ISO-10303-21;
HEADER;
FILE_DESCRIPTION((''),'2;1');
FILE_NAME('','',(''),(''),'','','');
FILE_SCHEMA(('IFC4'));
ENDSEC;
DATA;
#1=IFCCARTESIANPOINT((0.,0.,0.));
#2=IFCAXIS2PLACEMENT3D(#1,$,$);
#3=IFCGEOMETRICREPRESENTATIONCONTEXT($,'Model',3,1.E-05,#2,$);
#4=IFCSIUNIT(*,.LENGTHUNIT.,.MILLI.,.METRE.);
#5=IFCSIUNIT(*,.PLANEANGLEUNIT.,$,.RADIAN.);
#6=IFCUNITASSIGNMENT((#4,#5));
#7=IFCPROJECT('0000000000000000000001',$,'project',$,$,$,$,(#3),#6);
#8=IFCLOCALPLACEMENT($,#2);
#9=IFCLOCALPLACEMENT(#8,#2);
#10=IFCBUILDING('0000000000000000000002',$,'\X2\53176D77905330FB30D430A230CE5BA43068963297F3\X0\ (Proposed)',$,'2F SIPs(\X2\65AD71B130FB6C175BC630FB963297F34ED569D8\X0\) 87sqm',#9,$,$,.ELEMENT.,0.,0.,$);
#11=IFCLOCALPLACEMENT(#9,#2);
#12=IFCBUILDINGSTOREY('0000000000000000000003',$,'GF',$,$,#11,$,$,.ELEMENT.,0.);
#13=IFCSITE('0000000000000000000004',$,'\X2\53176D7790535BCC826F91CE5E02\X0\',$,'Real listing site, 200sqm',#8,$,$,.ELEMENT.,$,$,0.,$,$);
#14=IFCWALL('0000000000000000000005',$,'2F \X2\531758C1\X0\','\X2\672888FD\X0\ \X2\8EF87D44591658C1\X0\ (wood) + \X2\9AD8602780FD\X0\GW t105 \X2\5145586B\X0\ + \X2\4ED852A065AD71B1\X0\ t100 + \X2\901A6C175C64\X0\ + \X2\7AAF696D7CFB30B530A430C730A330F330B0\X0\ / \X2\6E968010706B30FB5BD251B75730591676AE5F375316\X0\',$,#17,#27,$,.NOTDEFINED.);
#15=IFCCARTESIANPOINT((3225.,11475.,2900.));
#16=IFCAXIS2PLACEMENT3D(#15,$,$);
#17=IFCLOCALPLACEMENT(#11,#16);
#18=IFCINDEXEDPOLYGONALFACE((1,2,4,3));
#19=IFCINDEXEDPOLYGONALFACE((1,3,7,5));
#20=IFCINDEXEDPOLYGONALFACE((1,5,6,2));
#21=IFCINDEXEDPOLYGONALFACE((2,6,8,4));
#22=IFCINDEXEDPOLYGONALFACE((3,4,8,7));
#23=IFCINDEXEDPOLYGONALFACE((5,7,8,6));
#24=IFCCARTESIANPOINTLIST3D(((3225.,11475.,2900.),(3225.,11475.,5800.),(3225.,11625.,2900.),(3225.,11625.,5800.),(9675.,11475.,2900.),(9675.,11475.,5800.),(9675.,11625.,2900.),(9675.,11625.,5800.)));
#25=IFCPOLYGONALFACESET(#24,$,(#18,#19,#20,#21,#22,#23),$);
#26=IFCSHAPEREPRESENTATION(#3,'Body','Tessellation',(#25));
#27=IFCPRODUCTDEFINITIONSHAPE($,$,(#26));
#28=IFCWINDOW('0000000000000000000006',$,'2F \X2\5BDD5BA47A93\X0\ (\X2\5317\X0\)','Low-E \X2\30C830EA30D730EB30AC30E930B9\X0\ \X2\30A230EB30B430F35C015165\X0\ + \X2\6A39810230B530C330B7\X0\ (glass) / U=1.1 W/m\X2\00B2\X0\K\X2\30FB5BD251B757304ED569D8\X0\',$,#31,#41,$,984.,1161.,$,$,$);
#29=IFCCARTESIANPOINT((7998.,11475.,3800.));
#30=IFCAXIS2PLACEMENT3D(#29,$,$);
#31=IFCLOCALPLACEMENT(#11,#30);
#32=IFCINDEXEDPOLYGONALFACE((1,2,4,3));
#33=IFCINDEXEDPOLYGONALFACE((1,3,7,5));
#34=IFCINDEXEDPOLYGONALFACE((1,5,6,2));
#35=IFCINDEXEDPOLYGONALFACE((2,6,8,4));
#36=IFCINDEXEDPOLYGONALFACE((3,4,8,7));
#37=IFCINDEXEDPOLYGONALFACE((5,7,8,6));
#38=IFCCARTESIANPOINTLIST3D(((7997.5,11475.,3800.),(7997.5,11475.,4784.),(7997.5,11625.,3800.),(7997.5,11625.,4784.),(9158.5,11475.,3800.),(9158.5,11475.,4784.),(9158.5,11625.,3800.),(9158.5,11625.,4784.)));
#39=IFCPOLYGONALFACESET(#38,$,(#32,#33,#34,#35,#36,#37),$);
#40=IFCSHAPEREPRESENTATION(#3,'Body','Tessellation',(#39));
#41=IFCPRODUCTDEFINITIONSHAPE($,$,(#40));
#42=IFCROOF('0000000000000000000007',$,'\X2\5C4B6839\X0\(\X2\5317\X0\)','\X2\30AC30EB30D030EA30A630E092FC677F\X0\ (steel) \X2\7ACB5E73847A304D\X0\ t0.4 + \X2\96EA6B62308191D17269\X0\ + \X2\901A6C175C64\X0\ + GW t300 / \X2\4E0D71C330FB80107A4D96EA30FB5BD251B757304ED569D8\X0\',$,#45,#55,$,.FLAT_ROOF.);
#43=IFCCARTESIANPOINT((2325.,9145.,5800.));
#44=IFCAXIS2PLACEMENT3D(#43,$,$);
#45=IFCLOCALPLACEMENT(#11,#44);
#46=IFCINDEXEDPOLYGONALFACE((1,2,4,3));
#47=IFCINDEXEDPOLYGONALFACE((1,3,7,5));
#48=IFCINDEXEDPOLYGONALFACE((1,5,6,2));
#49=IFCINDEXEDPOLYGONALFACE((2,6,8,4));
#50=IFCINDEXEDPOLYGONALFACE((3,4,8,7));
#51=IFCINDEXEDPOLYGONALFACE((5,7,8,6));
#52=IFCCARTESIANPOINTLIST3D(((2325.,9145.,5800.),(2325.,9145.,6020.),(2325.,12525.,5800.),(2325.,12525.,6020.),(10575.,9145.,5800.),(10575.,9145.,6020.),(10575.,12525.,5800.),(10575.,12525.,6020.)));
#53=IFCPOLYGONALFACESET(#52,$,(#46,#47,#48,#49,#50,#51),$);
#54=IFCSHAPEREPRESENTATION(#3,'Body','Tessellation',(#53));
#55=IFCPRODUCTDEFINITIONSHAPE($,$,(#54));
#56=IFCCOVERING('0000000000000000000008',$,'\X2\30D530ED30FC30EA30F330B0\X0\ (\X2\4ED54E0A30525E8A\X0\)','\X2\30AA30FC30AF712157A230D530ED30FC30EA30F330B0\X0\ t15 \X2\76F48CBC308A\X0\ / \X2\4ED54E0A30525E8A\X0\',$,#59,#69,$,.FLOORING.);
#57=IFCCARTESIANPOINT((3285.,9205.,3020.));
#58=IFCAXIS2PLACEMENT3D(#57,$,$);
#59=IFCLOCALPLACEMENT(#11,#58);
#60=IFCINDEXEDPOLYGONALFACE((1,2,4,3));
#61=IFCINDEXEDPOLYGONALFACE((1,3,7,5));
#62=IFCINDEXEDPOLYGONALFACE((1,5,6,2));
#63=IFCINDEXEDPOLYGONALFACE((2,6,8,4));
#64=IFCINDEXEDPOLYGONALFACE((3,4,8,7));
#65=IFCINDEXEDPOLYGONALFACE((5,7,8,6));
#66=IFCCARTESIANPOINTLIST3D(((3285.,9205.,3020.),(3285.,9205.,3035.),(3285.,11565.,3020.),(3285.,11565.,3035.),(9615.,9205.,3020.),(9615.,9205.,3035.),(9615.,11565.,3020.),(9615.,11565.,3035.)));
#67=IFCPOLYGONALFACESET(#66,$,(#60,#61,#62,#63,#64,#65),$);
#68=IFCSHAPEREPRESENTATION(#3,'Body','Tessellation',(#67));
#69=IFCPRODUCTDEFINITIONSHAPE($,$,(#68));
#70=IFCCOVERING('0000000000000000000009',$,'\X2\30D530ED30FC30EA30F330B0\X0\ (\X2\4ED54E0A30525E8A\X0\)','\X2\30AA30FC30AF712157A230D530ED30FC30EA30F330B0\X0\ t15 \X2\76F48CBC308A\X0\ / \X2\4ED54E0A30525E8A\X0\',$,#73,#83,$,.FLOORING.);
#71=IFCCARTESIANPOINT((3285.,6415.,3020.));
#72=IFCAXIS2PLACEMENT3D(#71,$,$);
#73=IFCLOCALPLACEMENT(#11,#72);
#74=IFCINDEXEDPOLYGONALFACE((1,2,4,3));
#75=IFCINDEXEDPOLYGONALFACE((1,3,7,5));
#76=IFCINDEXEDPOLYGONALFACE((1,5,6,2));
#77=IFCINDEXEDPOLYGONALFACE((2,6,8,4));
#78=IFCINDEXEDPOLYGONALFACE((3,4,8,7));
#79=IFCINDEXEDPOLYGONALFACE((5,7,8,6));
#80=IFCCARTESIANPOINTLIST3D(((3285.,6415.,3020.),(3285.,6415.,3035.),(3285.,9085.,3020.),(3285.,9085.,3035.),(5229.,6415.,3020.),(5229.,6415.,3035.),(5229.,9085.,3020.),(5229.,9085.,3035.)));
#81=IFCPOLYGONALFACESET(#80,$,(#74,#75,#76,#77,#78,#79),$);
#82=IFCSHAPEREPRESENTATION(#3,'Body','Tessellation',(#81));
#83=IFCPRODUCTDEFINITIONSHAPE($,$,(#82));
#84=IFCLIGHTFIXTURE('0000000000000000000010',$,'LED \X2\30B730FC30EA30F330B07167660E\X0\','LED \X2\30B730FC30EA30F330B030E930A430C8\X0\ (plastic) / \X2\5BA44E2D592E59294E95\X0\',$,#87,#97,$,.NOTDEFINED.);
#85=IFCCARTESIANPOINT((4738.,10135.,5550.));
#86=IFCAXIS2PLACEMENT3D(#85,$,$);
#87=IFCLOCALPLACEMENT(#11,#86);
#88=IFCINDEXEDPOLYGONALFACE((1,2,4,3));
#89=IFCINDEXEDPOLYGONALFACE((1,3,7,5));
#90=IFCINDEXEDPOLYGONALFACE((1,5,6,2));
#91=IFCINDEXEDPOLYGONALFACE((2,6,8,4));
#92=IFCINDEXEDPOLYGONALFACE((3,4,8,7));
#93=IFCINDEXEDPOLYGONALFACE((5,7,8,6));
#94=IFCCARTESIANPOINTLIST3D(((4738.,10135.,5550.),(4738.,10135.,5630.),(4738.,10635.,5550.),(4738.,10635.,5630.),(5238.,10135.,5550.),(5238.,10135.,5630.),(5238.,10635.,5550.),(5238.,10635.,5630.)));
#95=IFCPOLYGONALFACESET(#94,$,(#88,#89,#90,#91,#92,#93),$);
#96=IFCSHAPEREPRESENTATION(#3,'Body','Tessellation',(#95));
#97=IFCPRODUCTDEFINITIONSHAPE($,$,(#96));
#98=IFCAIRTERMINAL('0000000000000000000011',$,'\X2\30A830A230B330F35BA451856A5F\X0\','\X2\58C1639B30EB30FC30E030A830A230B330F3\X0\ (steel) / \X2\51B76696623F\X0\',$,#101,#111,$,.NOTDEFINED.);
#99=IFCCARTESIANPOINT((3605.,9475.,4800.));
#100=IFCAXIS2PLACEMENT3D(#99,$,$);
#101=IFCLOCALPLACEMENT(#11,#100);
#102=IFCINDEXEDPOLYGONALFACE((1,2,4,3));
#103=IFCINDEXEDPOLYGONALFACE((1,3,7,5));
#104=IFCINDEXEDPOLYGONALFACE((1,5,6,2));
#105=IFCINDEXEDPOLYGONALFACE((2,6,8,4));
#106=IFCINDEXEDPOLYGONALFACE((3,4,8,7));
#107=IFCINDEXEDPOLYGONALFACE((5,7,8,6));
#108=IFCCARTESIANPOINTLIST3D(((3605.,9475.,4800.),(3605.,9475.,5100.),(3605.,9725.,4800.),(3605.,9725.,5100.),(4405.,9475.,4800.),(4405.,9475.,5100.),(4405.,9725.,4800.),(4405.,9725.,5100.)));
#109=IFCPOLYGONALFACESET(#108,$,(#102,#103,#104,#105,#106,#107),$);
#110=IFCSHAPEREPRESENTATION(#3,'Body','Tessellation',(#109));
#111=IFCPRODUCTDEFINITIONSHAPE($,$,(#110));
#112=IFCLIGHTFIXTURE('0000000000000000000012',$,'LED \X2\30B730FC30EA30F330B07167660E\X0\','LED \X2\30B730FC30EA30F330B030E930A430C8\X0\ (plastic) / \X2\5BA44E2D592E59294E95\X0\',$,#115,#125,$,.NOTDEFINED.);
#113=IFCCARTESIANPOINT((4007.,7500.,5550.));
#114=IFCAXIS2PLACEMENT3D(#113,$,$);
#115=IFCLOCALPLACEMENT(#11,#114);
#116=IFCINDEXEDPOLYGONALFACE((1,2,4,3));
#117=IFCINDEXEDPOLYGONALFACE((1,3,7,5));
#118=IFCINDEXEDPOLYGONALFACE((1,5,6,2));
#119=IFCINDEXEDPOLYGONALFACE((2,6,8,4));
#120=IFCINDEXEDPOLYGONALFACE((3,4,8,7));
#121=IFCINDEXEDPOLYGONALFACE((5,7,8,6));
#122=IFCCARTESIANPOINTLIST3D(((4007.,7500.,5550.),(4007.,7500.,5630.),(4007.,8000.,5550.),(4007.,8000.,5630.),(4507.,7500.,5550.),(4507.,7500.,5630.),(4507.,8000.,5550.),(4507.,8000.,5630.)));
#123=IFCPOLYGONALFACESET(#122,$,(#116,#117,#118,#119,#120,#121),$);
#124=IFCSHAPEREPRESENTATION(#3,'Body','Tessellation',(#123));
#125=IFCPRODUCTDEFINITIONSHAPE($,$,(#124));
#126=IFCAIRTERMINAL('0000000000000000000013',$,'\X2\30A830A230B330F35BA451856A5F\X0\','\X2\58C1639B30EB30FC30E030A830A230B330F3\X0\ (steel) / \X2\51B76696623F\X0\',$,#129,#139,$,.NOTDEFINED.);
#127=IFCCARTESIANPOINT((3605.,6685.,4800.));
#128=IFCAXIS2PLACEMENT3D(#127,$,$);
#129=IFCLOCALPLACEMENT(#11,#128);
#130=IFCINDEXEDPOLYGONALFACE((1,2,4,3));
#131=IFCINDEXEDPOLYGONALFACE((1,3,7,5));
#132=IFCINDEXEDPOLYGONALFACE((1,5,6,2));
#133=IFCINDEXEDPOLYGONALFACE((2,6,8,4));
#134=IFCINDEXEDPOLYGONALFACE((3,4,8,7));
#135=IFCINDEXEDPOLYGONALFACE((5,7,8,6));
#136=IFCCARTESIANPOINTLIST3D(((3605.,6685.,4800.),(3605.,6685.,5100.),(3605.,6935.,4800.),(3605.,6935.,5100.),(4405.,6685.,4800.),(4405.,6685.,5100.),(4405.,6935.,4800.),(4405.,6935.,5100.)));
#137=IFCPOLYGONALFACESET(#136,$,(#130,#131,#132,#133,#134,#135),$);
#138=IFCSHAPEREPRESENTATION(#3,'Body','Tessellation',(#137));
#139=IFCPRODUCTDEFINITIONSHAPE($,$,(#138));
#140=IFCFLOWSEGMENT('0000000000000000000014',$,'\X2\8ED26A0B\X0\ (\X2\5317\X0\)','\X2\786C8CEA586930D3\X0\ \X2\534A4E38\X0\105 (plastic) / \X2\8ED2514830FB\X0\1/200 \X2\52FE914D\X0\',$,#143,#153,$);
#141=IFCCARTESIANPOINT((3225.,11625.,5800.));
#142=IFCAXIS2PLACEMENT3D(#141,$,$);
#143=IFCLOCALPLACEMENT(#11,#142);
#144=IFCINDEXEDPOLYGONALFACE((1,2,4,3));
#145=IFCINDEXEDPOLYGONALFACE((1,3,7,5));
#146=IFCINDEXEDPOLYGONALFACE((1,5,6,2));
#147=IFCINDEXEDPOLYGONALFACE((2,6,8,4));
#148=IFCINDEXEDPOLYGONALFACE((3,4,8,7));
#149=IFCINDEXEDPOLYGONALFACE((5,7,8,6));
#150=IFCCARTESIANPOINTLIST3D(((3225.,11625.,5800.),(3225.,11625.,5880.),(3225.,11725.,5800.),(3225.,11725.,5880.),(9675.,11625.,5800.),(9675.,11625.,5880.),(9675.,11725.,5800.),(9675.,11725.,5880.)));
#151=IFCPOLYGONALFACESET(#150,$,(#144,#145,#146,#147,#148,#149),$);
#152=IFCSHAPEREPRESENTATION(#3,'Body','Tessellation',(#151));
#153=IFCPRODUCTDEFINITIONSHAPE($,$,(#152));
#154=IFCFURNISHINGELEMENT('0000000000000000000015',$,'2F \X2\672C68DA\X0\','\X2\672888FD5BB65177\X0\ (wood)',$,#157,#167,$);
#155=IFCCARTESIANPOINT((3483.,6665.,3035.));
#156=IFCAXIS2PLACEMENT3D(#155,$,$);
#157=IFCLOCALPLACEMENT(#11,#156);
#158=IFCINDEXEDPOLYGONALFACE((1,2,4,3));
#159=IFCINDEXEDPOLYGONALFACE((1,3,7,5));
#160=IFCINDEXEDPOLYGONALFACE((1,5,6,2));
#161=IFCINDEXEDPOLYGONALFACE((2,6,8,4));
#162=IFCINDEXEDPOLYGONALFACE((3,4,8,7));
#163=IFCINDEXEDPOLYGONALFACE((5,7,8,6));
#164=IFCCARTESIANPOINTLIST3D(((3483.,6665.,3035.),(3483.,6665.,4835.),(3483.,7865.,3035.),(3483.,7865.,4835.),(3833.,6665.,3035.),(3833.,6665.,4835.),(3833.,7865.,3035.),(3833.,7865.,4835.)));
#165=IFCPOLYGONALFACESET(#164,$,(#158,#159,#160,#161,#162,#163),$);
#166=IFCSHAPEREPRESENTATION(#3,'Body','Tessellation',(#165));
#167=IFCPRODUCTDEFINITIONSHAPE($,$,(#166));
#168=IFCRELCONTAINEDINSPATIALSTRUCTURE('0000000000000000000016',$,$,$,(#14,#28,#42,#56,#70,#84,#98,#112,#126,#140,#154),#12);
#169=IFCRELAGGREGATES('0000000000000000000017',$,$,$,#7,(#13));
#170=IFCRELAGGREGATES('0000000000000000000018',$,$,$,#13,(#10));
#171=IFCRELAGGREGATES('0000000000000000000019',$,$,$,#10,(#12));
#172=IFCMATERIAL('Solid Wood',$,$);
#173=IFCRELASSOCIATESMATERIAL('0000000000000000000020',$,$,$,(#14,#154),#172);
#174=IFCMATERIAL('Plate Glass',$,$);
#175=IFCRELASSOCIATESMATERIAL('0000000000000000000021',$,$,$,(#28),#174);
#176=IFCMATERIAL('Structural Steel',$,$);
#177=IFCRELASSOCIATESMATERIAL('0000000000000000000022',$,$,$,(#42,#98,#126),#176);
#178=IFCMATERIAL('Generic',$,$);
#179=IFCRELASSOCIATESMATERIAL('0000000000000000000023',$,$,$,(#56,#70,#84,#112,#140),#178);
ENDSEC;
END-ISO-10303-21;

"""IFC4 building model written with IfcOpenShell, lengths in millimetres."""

from ifc_helpers import new_model, si_unit, frame, frame_2d, origin, place, context, project, spatial, rectangle, extrude, material, element, fill, save


model = new_model("IFC4")

# Units and contexts
model_context = context("Model", 3, precision=1e-05, world=origin())
ifc_project = project(units=[si_unit("LENGTHUNIT", "METRE", prefix="MILLI"), si_unit("PLANEANGLEUNIT", "RADIAN")], contexts=[model_context])

# Site, building, storey
site_placement = place(None, origin())
site = spatial("IfcSite", under=ifc_project, at=site_placement, Name="北海道富良野市", ObjectType="Real listing site, 200sqm", CompositionType="ELEMENT", RefElevation=0.0)
building_placement = place(site_placement, origin())
building = spatial("IfcBuilding", under=site, at=building_placement, Name="北海道・ピアノ室と防音 (Proposed)", ObjectType="2F SIPs(断熱・気密・防音仕様) 87sqm", CompositionType="ELEMENT", ElevationOfRefHeight=0.0, ElevationOfTerrain=0.0)
storey_placement = place(building_placement, origin())
storey = spatial("IfcBuildingStorey", under=building, at=storey_placement, Name="GF", CompositionType="ELEMENT", Elevation=0.0)

# Shared definitions
ifc_material_1 = material(Name="Solid Wood")

# Wall, opening, window
wall_placement = place(storey_placement, frame((3225.0, 11475.0, 2900.0)))
wall = element("IfcWall", 1, at=wall_placement, inside=storey, material=ifc_material_1, Name="2F 北壁", Description="木製 軸組外壁 (wood) + 高性能GW t105 充填 + 付加断熱 t100 + 通気層 + 窯業系サイディング / 準耐火・寒冷地外皮強化", PredefinedType="NOTDEFINED", context=model_context, shape_type="SweptSolid", body=[
    extrude(rectangle(XDim=6450.0, YDim=150.0, at=frame_2d((3225.0, 75.0))), frame((3225.0, 11475.0, 2900.0)), (0.0, 0.0, 1.0), 2900.0),
])
opening_placement = place(storey_placement, frame((7998.0, 11475.0, 3800.0)))
opening = element("IfcOpeningElement", 2, at=opening_placement, cuts=wall, PredefinedType="NOTDEFINED", context=model_context, shape_type="SweptSolid", body=[
    extrude(rectangle(XDim=1161.0, YDim=150.0, at=frame_2d((580.0, 75.0))), frame((7998.0, 11475.0, 3800.0)), (0.0, 0.0, 1.0), 984.0),
])
ifc_material_2 = material(Name="Plate Glass")
window_placement = place(storey_placement, frame((7998.0, 11475.0, 3800.0)))
window = element("IfcWindow", 3, at=window_placement, inside=storey, material=ifc_material_2, Name="2F 寝室窓 (北)", Description="Low-E トリプルガラス アルゴン封入 + 樹脂サッシ (glass) / U=1.1 W/m²K・寒冷地仕様", OverallHeight=984.0, OverallWidth=1161.0, context=model_context, shape_type="SweptSolid", body=[
    extrude(rectangle(XDim=1161.0, YDim=150.0, at=frame_2d((580.0, 75.0))), frame((7998.0, 11475.0, 3800.0)), (0.0, 0.0, 1.0), 984.0),
])
fill(opening, window)

# Roof
ifc_material_3 = material(Name="Structural Steel")
for number, where, name in (
    (4, (2325.0, 9145.0, 5800.0), "屋根(北)"),
):
    element("IfcRoof", number, at=place(storey_placement, frame(where)), inside=storey, material=ifc_material_3, Name=name, Description="ガルバリウム鋼板 (steel) 立平葺き t0.4 + 雪止め金物 + 通気層 + GW t300 / 不燃・耐積雪・寒冷地仕様", PredefinedType="FLAT_ROOF", context=model_context, shape_type="SweptSolid", body=[
        extrude(rectangle(XDim=8250.0, YDim=3380.0, at=frame_2d((4125.0, 1690.0))), frame((2325.0, 9145.0, 5800.0)), (0.0, 0.0, 1.0), 220.0),
    ])

# Coverings
ifc_material_4 = material(Name="Generic")
covering_1_placement = place(storey_placement, frame((3285.0, 9205.0, 3020.0)))
element("IfcCovering", 5, at=covering_1_placement, inside=storey, material=ifc_material_4, Name="フローリング (仕上げ床)", Description="オーク無垢フローリング t15 直貼り / 仕上げ床", PredefinedType="FLOORING", context=model_context, shape_type="SweptSolid", body=[
    extrude(rectangle(XDim=6330.0, YDim=2360.0, at=frame_2d((3165.0, 1180.0))), frame((3285.0, 9205.0, 3020.0)), (0.0, 0.0, 1.0), 15.0),
])
covering_2_placement = place(storey_placement, frame((3285.0, 6415.0, 3020.0)))
element("IfcCovering", 6, at=covering_2_placement, inside=storey, material=ifc_material_4, Name="フローリング (仕上げ床)", Description="オーク無垢フローリング t15 直貼り / 仕上げ床", PredefinedType="FLOORING", context=model_context, shape_type="SweptSolid", body=[
    extrude(rectangle(XDim=1944.0, YDim=2670.0, at=frame_2d((972.0, 1335.0))), frame((3285.0, 6415.0, 3020.0)), (0.0, 0.0, 1.0), 15.0),
])

# Light fixture
light_fixture_1_placement = place(storey_placement, frame((4738.0, 10135.0, 5550.0)))
element("IfcLightFixture", 7, at=light_fixture_1_placement, inside=storey, material=ifc_material_4, Name="LED シーリング照明", Description="LED シーリングライト (plastic) / 室中央天井", PredefinedType="NOTDEFINED", context=model_context, shape_type="SweptSolid", body=[
    extrude(rectangle(XDim=500.0, YDim=500.0, at=frame_2d((250.0, 250.0))), frame((4738.0, 10135.0, 5550.0)), (0.0, 0.0, 1.0), 80.0),
])

# Air terminal
air_terminal_1_placement = place(storey_placement, frame((3605.0, 9475.0, 4800.0)))
element("IfcAirTerminal", 8, at=air_terminal_1_placement, inside=storey, material=ifc_material_3, Name="エアコン室内機", Description="壁掛ルームエアコン (steel) / 冷暖房", PredefinedType="NOTDEFINED", context=model_context, shape_type="SweptSolid", body=[
    extrude(rectangle(XDim=800.0, YDim=250.0, at=frame_2d((400.0, 125.0))), frame((3605.0, 9475.0, 4800.0)), (0.0, 0.0, 1.0), 300.0),
])

# Light fixture
light_fixture_2_placement = place(storey_placement, frame((4007.0, 7500.0, 5550.0)))
element("IfcLightFixture", 9, at=light_fixture_2_placement, inside=storey, material=ifc_material_4, Name="LED シーリング照明", Description="LED シーリングライト (plastic) / 室中央天井", PredefinedType="NOTDEFINED", context=model_context, shape_type="SweptSolid", body=[
    extrude(rectangle(XDim=500.0, YDim=500.0, at=frame_2d((250.0, 250.0))), frame((4007.0, 7500.0, 5550.0)), (0.0, 0.0, 1.0), 80.0),
])

# Air terminal
air_terminal_2_placement = place(storey_placement, frame((3605.0, 6685.0, 4800.0)))
element("IfcAirTerminal", 10, at=air_terminal_2_placement, inside=storey, material=ifc_material_3, Name="エアコン室内機", Description="壁掛ルームエアコン (steel) / 冷暖房", PredefinedType="NOTDEFINED", context=model_context, shape_type="SweptSolid", body=[
    extrude(rectangle(XDim=800.0, YDim=250.0, at=frame_2d((400.0, 125.0))), frame((3605.0, 6685.0, 4800.0)), (0.0, 0.0, 1.0), 300.0),
])

# Flow segment
flow_segment_placement = place(storey_placement, frame((3225.0, 11625.0, 5800.0)))
element("IfcFlowSegment", 11, at=flow_segment_placement, inside=storey, material=ifc_material_4, Name="軒樋 (北)", Description="硬質塩ビ 半丸105 (plastic) / 軒先・1/200 勾配", context=model_context, shape_type="SweptSolid", body=[
    extrude(rectangle(XDim=6450.0, YDim=100.0, at=frame_2d((3225.0, 50.0))), frame((3225.0, 11625.0, 5800.0)), (0.0, 0.0, 1.0), 80.0),
])

# Furnishing element
furnishing_placement = place(storey_placement, frame((3483.0, 6665.0, 3035.0)))
element("IfcFurnishingElement", 12, at=furnishing_placement, inside=storey, material=ifc_material_1, Name="2F 本棚", Description="木製家具 (wood)", context=model_context, shape_type="SweptSolid", body=[
    extrude(rectangle(XDim=350.0, YDim=1200.0, at=frame_2d((175.0, 600.0))), frame((3483.0, 6665.0, 3035.0)), (0.0, 0.0, 1.0), 1800.0),
])

save(model, "model.ifc")
